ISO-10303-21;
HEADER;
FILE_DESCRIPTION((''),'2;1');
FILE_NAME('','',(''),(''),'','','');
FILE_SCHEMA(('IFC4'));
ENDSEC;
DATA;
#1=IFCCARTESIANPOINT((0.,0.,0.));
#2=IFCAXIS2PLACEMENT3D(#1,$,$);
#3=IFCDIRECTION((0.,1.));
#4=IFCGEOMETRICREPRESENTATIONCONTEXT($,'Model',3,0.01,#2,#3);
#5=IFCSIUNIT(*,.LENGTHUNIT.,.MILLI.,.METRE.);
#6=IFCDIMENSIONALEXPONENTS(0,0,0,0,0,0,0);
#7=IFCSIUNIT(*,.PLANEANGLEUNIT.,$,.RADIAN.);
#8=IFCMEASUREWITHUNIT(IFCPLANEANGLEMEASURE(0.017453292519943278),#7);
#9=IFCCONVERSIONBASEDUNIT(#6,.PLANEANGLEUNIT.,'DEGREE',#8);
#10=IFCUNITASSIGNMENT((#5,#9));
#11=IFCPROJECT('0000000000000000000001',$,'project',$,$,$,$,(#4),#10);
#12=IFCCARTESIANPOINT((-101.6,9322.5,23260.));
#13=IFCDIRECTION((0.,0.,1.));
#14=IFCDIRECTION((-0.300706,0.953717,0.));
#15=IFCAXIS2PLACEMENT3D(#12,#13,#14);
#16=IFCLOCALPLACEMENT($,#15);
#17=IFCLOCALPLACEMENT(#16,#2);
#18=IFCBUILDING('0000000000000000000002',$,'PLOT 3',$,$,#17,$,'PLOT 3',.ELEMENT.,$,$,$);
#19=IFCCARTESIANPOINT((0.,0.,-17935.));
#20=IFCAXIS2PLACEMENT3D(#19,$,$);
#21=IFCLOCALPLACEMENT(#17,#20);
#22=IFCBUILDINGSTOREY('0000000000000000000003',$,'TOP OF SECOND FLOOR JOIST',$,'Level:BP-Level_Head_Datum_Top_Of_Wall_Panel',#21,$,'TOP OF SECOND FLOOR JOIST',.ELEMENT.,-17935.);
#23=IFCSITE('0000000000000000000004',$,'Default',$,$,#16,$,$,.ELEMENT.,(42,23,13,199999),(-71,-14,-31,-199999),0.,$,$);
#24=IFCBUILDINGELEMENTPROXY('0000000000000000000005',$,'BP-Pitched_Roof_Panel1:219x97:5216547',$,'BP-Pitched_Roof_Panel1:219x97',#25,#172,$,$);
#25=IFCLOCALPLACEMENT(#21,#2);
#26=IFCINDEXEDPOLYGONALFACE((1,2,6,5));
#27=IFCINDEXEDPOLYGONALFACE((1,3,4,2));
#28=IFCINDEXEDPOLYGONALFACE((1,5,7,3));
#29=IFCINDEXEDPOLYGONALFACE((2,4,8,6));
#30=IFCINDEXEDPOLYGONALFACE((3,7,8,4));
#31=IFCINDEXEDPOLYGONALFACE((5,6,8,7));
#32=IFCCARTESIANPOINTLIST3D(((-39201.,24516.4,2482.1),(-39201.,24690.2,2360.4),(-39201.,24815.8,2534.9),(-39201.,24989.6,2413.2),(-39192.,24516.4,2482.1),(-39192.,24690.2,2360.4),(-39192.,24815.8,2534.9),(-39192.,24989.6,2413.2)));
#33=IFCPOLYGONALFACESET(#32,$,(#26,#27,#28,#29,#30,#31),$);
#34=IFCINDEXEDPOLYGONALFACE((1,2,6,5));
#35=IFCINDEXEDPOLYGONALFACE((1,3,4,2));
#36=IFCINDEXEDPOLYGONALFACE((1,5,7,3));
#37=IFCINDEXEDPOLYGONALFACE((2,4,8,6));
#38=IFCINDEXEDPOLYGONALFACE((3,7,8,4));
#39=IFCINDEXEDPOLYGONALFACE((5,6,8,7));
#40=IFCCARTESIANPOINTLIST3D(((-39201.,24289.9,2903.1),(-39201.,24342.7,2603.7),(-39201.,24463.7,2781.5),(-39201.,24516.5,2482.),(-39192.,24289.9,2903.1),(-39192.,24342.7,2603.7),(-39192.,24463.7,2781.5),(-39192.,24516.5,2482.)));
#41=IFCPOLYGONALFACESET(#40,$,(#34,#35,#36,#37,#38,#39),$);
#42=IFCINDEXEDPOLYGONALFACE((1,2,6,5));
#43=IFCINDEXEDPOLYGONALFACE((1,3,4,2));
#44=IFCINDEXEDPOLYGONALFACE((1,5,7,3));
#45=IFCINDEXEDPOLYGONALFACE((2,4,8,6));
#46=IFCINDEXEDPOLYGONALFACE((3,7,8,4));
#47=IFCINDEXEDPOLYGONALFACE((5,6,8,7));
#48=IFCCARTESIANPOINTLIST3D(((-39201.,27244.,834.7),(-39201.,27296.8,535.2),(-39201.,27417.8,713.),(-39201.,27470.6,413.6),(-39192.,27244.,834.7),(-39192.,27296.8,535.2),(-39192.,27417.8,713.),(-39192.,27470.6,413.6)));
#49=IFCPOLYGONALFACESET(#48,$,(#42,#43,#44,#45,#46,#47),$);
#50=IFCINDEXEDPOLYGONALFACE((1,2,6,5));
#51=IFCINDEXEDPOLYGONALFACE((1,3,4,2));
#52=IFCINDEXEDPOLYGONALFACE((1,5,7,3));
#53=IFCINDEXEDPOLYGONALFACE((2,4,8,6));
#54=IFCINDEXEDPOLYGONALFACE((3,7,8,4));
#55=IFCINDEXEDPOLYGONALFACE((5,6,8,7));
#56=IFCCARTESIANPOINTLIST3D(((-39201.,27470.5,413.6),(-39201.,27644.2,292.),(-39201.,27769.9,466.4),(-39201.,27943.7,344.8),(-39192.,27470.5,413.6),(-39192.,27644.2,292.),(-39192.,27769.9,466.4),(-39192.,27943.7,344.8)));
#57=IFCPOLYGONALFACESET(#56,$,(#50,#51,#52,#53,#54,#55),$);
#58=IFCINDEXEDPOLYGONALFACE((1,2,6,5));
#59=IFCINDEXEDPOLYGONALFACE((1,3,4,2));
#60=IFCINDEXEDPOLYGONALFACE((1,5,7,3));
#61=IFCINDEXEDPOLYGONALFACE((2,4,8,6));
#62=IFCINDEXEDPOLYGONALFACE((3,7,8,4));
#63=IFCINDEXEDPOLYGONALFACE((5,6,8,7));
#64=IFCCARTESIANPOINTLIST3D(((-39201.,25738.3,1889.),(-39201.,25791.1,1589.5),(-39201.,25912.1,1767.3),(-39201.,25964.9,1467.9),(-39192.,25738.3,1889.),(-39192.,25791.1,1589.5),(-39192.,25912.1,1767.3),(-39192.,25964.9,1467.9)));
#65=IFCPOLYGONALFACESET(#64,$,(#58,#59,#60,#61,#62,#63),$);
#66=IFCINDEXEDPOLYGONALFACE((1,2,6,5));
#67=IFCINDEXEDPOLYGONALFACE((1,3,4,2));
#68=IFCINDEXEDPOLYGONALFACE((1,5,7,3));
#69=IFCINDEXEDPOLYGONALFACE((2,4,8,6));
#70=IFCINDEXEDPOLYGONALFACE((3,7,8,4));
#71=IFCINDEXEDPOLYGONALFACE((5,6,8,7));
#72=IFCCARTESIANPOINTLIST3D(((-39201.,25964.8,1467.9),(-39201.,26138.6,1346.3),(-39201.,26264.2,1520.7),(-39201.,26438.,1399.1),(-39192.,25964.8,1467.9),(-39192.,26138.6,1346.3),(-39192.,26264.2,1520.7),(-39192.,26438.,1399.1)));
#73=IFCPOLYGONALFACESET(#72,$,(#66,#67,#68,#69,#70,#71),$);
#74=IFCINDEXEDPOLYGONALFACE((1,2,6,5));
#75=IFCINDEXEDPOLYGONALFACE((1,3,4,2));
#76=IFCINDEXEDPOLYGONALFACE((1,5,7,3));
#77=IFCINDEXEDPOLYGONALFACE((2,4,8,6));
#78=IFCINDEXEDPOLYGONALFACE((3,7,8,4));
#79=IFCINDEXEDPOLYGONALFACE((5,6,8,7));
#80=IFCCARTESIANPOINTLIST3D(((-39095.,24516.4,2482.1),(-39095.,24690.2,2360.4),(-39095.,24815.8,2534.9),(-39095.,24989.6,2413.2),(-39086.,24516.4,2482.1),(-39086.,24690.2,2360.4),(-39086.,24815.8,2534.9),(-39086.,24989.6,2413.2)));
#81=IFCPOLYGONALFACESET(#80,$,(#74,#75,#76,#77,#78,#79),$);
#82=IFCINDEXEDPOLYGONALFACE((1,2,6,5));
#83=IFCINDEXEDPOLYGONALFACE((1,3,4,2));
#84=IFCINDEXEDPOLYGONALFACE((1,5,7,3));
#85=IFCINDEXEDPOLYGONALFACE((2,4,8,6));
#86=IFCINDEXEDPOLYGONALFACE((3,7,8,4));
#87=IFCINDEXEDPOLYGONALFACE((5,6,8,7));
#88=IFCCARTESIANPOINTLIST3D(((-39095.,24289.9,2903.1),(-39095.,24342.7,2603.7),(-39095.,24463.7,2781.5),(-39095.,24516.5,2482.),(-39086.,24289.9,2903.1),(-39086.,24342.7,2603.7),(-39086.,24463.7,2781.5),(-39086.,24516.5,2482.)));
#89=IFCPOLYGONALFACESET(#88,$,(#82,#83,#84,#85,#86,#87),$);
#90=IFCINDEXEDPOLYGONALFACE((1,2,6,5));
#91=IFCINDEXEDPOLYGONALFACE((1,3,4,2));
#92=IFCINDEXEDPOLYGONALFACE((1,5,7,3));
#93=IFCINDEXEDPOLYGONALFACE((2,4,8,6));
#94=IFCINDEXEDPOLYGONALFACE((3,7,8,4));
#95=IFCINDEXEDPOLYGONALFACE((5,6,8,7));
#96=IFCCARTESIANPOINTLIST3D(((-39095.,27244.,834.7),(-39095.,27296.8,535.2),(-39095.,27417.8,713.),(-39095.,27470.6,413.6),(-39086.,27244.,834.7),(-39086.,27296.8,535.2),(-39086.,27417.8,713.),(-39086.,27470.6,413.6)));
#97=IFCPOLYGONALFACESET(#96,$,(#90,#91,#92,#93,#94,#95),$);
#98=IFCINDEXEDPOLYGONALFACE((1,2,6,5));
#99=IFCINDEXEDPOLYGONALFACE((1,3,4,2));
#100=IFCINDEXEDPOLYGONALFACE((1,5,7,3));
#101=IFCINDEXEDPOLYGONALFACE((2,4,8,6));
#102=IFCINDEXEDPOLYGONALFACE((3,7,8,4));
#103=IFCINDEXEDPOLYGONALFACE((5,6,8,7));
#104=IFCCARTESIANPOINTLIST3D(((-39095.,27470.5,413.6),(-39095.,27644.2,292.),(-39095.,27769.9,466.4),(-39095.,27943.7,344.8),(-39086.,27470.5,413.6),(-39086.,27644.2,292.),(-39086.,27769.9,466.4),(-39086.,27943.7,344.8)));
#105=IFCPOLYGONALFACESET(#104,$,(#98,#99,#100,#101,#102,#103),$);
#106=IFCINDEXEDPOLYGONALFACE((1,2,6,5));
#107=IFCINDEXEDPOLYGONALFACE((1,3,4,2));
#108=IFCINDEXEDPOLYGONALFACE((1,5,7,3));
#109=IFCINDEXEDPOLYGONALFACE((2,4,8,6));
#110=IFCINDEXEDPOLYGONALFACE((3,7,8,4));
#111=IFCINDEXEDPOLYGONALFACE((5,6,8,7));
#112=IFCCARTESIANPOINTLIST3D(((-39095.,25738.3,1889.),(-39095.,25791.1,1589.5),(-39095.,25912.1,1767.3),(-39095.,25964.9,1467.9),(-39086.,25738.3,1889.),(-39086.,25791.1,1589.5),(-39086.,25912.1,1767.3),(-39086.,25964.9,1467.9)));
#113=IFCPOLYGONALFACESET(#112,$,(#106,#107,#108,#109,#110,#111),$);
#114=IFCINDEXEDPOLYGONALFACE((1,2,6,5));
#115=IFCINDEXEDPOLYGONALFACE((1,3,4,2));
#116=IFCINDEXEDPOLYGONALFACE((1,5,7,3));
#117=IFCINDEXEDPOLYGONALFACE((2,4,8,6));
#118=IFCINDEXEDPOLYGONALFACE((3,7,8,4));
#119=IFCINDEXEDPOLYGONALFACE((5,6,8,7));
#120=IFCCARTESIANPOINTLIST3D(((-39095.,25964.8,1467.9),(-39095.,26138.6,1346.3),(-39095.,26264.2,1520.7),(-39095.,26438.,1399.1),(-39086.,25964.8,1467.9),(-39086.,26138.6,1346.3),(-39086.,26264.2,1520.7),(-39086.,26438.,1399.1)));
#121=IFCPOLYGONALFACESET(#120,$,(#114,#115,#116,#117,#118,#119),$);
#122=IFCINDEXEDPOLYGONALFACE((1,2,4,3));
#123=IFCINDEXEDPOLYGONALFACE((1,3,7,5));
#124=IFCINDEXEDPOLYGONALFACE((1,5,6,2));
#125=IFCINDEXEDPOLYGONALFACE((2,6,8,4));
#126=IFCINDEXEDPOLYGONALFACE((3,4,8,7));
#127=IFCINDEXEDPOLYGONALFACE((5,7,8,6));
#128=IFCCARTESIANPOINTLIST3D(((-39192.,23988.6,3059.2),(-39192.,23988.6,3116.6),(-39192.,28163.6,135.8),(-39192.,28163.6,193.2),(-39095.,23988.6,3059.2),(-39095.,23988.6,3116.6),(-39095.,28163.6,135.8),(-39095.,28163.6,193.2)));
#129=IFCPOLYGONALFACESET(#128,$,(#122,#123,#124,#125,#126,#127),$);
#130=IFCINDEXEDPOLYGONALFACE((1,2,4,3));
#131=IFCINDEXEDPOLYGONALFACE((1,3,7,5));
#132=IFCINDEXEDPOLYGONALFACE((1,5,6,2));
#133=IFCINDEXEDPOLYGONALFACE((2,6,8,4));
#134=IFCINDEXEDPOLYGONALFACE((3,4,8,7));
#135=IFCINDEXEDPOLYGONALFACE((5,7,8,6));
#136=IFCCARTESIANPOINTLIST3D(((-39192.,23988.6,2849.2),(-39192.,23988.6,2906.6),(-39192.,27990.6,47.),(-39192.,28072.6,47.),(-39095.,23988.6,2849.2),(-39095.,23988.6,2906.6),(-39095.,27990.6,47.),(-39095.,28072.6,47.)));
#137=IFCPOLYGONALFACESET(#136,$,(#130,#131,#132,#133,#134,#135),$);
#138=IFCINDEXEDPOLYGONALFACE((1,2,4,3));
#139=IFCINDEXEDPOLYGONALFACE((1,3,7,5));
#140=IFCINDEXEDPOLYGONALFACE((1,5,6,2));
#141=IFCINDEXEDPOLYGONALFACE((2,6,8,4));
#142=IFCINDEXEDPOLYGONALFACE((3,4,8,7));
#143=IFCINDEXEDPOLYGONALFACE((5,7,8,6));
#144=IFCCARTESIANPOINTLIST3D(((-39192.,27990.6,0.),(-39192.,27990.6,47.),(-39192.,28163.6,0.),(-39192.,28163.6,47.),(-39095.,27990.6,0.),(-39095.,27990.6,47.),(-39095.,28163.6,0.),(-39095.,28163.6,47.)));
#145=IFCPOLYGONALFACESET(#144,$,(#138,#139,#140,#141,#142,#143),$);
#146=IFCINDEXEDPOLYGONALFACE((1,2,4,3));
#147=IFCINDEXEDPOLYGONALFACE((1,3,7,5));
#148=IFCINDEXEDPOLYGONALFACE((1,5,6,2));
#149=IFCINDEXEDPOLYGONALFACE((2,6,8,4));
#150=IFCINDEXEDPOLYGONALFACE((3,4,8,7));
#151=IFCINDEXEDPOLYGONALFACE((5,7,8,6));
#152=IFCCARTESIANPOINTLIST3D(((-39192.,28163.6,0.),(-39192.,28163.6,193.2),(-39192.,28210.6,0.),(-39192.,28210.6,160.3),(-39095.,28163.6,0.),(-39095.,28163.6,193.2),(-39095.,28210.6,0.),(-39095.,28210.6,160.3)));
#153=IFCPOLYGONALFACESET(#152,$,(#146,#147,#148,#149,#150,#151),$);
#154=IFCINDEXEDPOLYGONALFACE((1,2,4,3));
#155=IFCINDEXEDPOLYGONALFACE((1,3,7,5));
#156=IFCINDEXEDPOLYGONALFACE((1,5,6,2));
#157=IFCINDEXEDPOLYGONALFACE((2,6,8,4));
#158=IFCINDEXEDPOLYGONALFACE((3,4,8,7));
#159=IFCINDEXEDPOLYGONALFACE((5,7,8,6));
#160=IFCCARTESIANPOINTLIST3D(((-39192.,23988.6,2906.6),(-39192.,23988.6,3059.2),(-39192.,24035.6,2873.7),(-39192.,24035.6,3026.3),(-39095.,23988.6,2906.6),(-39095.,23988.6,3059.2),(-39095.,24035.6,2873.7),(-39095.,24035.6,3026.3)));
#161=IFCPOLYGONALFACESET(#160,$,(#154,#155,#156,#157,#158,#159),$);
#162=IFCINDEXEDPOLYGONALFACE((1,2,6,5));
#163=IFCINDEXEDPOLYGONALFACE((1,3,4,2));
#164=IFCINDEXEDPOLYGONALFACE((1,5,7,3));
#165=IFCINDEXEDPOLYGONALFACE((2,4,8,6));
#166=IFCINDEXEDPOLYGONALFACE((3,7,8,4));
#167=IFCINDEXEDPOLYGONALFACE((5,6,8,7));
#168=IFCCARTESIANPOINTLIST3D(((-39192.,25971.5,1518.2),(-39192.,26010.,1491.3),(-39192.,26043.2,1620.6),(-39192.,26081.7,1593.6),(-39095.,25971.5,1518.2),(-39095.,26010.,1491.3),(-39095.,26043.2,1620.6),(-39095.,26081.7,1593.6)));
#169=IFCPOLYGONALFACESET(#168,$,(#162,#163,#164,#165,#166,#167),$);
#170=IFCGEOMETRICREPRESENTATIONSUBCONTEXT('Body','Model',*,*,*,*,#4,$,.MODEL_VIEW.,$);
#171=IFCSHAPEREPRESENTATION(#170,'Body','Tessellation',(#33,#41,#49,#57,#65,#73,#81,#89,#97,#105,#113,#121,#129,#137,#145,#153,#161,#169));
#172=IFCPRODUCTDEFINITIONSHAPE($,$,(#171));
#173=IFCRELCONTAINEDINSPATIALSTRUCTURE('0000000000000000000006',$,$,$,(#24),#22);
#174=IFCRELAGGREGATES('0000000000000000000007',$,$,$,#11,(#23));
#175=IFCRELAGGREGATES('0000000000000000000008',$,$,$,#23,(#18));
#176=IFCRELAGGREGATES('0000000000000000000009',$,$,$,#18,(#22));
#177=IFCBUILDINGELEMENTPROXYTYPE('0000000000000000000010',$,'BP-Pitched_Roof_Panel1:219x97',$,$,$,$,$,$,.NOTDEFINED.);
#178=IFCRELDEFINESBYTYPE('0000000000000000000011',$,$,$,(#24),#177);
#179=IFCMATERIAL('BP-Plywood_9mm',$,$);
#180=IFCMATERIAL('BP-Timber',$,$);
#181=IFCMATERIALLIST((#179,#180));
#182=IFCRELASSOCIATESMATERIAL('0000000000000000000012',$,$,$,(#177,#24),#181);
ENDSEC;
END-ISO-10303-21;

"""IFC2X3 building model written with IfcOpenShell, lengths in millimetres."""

from ifc_helpers import new_model, entity, si_unit, converted_unit, direction, frame, frame_2d, origin, origin_2d_with_axis, place, context, subcontext, project, spatial, polyline, rectangle, outline, extrude, source, transform, mapped, material, material_list, type_object, type_shapes, element, save


model = new_model("IFC2X3")

# Units and contexts
model_context = context("Model", 3, precision=0.01, world=origin(), true_north=direction((0.0, 1.0)))
body_context = subcontext(model_context, "Body", "Model", "MODEL_VIEW")
ifc_project = project(units=[si_unit("LENGTHUNIT", "METRE", prefix="MILLI"), converted_unit("PLANEANGLEUNIT", "DEGREE", entity("IfcPlaneAngleMeasure", 0.017453292519943278), si_unit("PLANEANGLEUNIT", "RADIAN"), dimensions=[0, 0, 0, 0, 0, 0, 0])], contexts=[model_context])

# Site, building, storey
site_placement = place(None, frame((-101.6, 9322.5, 23260.0), z_axis=(0.0, 0.0, 1.0), x_axis=(-0.300706, 0.953717, 0.0)))
site = spatial("IfcSite", under=ifc_project, at=site_placement, Name="Default", CompositionType="ELEMENT", RefLatitude=(42, 23, 13, 199999), RefLongitude=(-71, -14, -31, -199999), RefElevation=0.0)
building_placement = place(site_placement, origin())
building = spatial("IfcBuilding", under=site, at=building_placement, Name="PLOT 3", LongName="PLOT 3", CompositionType="ELEMENT")
storey_placement = place(building_placement, frame((0.0, 0.0, -17935.0)))
storey = spatial("IfcBuildingStorey", under=building, at=storey_placement, Name="TOP OF SECOND FLOOR JOIST", ObjectType="Level:BP-Level_Head_Datum_Top_Of_Wall_Panel", LongName="TOP OF SECOND FLOOR JOIST", CompositionType="ELEMENT", Elevation=-17935.0)

# Building element proxy
ifc_material_1 = material(Name="BP-Timber")
ifc_material_2 = material(Name="BP-Plywood_9mm")
ifc_material_list = material_list([ifc_material_2, ifc_material_1])
building_element_proxy_type_1 = type_object("IfcBuildingElementProxyType", Name="BP-Pitched_Roof_Panel1:219x97", PredefinedType="NOTDEFINED", material=ifc_material_list)
shared_shape_1 = source(origin(), body_context, "Body", "SweptSolid", [
    extrude(outline(polyline([(-77.0, -75.0), (227.0, -75.0), (77.0, 75.0), (-227.0, 75.0), (-77.0, -75.0)])), frame((35.3, -3956.0, 2447.7), z_axis=(0.0, 1.0, 0.0), x_axis=(-0.984808, 0.0, 0.173648)), (0.0, 0.0, 1.0), 9.0),
    extrude(outline(polyline([(1.4, -107.5), (213.6, -107.5), (-1.4, 107.5), (-213.6, 107.5), (1.4, -107.5)])), frame((385.1, -3956.0, 2692.6), z_axis=(0.0, 1.0, 0.0), x_axis=(-0.819152, 0.0, -0.573576)), (0.0, 0.0, 1.0), 9.0),
    extrude(outline(polyline([(1.4, -107.5), (213.6, -107.5), (-1.4, 107.5), (-213.6, 107.5), (1.4, -107.5)])), frame((-2569.0, -3956.0, 624.1), z_axis=(0.0, 1.0, 0.0), x_axis=(-0.819152, 0.0, -0.573576)), (0.0, 0.0, 1.0), 9.0),
    extrude(outline(polyline([(-77.0, -75.0), (227.0, -75.0), (77.0, 75.0), (-227.0, 75.0), (-77.0, -75.0)])), frame((-2918.8, -3956.0, 379.2), z_axis=(0.0, 1.0, 0.0), x_axis=(-0.984808, 0.0, 0.173648)), (0.0, 0.0, 1.0), 9.0),
    extrude(outline(polyline([(1.4, -107.5), (213.6, -107.5), (-1.4, 107.5), (-213.6, 107.5), (1.4, -107.5)])), frame((-1063.3, -3956.0, 1678.4), z_axis=(0.0, 1.0, 0.0), x_axis=(-0.819152, 0.0, -0.573576)), (0.0, 0.0, 1.0), 9.0),
    extrude(outline(polyline([(-77.0, -75.0), (227.0, -75.0), (77.0, 75.0), (-227.0, 75.0), (-77.0, -75.0)])), frame((-1413.1, -3956.0, 1433.5), z_axis=(0.0, 1.0, 0.0), x_axis=(-0.984808, 0.0, 0.173648)), (0.0, 0.0, 1.0), 9.0),
    extrude(outline(polyline([(-77.0, -75.0), (227.0, -75.0), (77.0, 75.0), (-227.0, 75.0), (-77.0, -75.0)])), frame((35.3, -3850.0, 2447.7), z_axis=(0.0, 1.0, 0.0), x_axis=(-0.984808, 0.0, 0.173648)), (0.0, 0.0, 1.0), 9.0),
    extrude(outline(polyline([(1.4, -107.5), (213.6, -107.5), (-1.4, 107.5), (-213.6, 107.5), (1.4, -107.5)])), frame((385.1, -3850.0, 2692.6), z_axis=(0.0, 1.0, 0.0), x_axis=(-0.819152, 0.0, -0.573576)), (0.0, 0.0, 1.0), 9.0),
    extrude(outline(polyline([(1.4, -107.5), (213.6, -107.5), (-1.4, 107.5), (-213.6, 107.5), (1.4, -107.5)])), frame((-2569.0, -3850.0, 624.1), z_axis=(0.0, 1.0, 0.0), x_axis=(-0.819152, 0.0, -0.573576)), (0.0, 0.0, 1.0), 9.0),
    extrude(outline(polyline([(-77.0, -75.0), (227.0, -75.0), (77.0, 75.0), (-227.0, 75.0), (-77.0, -75.0)])), frame((-2918.8, -3850.0, 379.2), z_axis=(0.0, 1.0, 0.0), x_axis=(-0.984808, 0.0, 0.173648)), (0.0, 0.0, 1.0), 9.0),
    extrude(outline(polyline([(1.4, -107.5), (213.6, -107.5), (-1.4, 107.5), (-213.6, 107.5), (1.4, -107.5)])), frame((-1063.3, -3850.0, 1678.4), z_axis=(0.0, 1.0, 0.0), x_axis=(-0.819152, 0.0, -0.573576)), (0.0, 0.0, 1.0), 9.0),
    extrude(outline(polyline([(-77.0, -75.0), (227.0, -75.0), (77.0, 75.0), (-227.0, 75.0), (-77.0, -75.0)])), frame((-1413.1, -3850.0, 1433.5), z_axis=(0.0, 1.0, 0.0), x_axis=(-0.984808, 0.0, 0.173648)), (0.0, 0.0, 1.0), 9.0),
    extrude(outline(polyline([(-1490.4, -2087.5), (-1433.0, -2087.5), (1490.4, 2087.5), (1433.0, 2087.5), (-1490.4, -2087.5)])), frame((-1287.8, -3947.0, 1626.2), z_axis=(0.0, 1.0, 0.0), x_axis=(0.0, 0.0, -1.0)), (0.0, 0.0, 1.0), 97.0),
    extrude(outline(polyline([(-1444.1, -2021.5), (-1386.8, -2021.5), (1415.5, 1980.5), (1415.5, 2062.5), (-1444.1, -2021.5)])), frame((-1221.8, -3947.0, 1462.5), z_axis=(0.0, 1.0, 0.0), x_axis=(0.0, 0.0, -1.0)), (0.0, 0.0, 1.0), 97.0),
    extrude(rectangle(XDim=173.0, YDim=97.0, at=origin_2d_with_axis()), frame((-3288.8, -3898.5, 0.0), z_axis=(0.0, 0.0, 1.0), x_axis=(-1.0, 0.0, 0.0)), (0.0, 0.0, 1.0), 47.0),
    extrude(outline(polyline([(22.0, -72.4), (79.4, -72.4), (-31.4, 85.9), (-69.9, 58.9), (22.0, -72.4)])), frame((-3398.8, -3947.0, 88.4), z_axis=(0.0, 1.0, 0.0), x_axis=(0.819152, 0.0, 0.573576)), (0.0, 0.0, 1.0), 97.0),
    extrude(outline(polyline([(15.1, -62.5), (72.5, -62.5), (-15.1, 62.5), (-72.5, 62.5), (15.1, -62.5)])), frame((776.2, -3947.0, 2966.5), z_axis=(0.0, 1.0, 0.0), x_axis=(0.819152, 0.0, 0.573576)), (0.0, 0.0, 1.0), 97.0),
    extrude(rectangle(XDim=47.0, YDim=97.0, at=frame_2d((0.0, 0.0), x_axis=(1.0, 0.0))), frame((-1202.4, -3898.5, 1504.7), z_axis=(-0.573576, 0.0, 0.819152), x_axis=(-0.819152, 0.0, -0.573576)), (0.0, 0.0, 1.0), 125.0),
])
type_shapes(building_element_proxy_type_1, [shared_shape_1])
for number, where, z_axis, x_axis, name in (
    (1, (-35245.0, 24788.3, 0.0), (0.0, 0.0, 1.0), (0.0, -1.0, 0.0), "BP-Pitched_Roof_Panel1:219x97:5216547"),
):
    element("IfcBuildingElementProxy", number, at=place(storey_placement, frame(where, z_axis=z_axis, x_axis=x_axis)), inside=storey, type_object=building_element_proxy_type_1, material=ifc_material_list, Name=name, ObjectType="BP-Pitched_Roof_Panel1:219x97", context=body_context, shape_type="MappedRepresentation", body=[
        mapped(shared_shape_1, transform((0.0, 0.0, 0.0), scale=1.0)),
    ])

save(model, "model.ifc")
